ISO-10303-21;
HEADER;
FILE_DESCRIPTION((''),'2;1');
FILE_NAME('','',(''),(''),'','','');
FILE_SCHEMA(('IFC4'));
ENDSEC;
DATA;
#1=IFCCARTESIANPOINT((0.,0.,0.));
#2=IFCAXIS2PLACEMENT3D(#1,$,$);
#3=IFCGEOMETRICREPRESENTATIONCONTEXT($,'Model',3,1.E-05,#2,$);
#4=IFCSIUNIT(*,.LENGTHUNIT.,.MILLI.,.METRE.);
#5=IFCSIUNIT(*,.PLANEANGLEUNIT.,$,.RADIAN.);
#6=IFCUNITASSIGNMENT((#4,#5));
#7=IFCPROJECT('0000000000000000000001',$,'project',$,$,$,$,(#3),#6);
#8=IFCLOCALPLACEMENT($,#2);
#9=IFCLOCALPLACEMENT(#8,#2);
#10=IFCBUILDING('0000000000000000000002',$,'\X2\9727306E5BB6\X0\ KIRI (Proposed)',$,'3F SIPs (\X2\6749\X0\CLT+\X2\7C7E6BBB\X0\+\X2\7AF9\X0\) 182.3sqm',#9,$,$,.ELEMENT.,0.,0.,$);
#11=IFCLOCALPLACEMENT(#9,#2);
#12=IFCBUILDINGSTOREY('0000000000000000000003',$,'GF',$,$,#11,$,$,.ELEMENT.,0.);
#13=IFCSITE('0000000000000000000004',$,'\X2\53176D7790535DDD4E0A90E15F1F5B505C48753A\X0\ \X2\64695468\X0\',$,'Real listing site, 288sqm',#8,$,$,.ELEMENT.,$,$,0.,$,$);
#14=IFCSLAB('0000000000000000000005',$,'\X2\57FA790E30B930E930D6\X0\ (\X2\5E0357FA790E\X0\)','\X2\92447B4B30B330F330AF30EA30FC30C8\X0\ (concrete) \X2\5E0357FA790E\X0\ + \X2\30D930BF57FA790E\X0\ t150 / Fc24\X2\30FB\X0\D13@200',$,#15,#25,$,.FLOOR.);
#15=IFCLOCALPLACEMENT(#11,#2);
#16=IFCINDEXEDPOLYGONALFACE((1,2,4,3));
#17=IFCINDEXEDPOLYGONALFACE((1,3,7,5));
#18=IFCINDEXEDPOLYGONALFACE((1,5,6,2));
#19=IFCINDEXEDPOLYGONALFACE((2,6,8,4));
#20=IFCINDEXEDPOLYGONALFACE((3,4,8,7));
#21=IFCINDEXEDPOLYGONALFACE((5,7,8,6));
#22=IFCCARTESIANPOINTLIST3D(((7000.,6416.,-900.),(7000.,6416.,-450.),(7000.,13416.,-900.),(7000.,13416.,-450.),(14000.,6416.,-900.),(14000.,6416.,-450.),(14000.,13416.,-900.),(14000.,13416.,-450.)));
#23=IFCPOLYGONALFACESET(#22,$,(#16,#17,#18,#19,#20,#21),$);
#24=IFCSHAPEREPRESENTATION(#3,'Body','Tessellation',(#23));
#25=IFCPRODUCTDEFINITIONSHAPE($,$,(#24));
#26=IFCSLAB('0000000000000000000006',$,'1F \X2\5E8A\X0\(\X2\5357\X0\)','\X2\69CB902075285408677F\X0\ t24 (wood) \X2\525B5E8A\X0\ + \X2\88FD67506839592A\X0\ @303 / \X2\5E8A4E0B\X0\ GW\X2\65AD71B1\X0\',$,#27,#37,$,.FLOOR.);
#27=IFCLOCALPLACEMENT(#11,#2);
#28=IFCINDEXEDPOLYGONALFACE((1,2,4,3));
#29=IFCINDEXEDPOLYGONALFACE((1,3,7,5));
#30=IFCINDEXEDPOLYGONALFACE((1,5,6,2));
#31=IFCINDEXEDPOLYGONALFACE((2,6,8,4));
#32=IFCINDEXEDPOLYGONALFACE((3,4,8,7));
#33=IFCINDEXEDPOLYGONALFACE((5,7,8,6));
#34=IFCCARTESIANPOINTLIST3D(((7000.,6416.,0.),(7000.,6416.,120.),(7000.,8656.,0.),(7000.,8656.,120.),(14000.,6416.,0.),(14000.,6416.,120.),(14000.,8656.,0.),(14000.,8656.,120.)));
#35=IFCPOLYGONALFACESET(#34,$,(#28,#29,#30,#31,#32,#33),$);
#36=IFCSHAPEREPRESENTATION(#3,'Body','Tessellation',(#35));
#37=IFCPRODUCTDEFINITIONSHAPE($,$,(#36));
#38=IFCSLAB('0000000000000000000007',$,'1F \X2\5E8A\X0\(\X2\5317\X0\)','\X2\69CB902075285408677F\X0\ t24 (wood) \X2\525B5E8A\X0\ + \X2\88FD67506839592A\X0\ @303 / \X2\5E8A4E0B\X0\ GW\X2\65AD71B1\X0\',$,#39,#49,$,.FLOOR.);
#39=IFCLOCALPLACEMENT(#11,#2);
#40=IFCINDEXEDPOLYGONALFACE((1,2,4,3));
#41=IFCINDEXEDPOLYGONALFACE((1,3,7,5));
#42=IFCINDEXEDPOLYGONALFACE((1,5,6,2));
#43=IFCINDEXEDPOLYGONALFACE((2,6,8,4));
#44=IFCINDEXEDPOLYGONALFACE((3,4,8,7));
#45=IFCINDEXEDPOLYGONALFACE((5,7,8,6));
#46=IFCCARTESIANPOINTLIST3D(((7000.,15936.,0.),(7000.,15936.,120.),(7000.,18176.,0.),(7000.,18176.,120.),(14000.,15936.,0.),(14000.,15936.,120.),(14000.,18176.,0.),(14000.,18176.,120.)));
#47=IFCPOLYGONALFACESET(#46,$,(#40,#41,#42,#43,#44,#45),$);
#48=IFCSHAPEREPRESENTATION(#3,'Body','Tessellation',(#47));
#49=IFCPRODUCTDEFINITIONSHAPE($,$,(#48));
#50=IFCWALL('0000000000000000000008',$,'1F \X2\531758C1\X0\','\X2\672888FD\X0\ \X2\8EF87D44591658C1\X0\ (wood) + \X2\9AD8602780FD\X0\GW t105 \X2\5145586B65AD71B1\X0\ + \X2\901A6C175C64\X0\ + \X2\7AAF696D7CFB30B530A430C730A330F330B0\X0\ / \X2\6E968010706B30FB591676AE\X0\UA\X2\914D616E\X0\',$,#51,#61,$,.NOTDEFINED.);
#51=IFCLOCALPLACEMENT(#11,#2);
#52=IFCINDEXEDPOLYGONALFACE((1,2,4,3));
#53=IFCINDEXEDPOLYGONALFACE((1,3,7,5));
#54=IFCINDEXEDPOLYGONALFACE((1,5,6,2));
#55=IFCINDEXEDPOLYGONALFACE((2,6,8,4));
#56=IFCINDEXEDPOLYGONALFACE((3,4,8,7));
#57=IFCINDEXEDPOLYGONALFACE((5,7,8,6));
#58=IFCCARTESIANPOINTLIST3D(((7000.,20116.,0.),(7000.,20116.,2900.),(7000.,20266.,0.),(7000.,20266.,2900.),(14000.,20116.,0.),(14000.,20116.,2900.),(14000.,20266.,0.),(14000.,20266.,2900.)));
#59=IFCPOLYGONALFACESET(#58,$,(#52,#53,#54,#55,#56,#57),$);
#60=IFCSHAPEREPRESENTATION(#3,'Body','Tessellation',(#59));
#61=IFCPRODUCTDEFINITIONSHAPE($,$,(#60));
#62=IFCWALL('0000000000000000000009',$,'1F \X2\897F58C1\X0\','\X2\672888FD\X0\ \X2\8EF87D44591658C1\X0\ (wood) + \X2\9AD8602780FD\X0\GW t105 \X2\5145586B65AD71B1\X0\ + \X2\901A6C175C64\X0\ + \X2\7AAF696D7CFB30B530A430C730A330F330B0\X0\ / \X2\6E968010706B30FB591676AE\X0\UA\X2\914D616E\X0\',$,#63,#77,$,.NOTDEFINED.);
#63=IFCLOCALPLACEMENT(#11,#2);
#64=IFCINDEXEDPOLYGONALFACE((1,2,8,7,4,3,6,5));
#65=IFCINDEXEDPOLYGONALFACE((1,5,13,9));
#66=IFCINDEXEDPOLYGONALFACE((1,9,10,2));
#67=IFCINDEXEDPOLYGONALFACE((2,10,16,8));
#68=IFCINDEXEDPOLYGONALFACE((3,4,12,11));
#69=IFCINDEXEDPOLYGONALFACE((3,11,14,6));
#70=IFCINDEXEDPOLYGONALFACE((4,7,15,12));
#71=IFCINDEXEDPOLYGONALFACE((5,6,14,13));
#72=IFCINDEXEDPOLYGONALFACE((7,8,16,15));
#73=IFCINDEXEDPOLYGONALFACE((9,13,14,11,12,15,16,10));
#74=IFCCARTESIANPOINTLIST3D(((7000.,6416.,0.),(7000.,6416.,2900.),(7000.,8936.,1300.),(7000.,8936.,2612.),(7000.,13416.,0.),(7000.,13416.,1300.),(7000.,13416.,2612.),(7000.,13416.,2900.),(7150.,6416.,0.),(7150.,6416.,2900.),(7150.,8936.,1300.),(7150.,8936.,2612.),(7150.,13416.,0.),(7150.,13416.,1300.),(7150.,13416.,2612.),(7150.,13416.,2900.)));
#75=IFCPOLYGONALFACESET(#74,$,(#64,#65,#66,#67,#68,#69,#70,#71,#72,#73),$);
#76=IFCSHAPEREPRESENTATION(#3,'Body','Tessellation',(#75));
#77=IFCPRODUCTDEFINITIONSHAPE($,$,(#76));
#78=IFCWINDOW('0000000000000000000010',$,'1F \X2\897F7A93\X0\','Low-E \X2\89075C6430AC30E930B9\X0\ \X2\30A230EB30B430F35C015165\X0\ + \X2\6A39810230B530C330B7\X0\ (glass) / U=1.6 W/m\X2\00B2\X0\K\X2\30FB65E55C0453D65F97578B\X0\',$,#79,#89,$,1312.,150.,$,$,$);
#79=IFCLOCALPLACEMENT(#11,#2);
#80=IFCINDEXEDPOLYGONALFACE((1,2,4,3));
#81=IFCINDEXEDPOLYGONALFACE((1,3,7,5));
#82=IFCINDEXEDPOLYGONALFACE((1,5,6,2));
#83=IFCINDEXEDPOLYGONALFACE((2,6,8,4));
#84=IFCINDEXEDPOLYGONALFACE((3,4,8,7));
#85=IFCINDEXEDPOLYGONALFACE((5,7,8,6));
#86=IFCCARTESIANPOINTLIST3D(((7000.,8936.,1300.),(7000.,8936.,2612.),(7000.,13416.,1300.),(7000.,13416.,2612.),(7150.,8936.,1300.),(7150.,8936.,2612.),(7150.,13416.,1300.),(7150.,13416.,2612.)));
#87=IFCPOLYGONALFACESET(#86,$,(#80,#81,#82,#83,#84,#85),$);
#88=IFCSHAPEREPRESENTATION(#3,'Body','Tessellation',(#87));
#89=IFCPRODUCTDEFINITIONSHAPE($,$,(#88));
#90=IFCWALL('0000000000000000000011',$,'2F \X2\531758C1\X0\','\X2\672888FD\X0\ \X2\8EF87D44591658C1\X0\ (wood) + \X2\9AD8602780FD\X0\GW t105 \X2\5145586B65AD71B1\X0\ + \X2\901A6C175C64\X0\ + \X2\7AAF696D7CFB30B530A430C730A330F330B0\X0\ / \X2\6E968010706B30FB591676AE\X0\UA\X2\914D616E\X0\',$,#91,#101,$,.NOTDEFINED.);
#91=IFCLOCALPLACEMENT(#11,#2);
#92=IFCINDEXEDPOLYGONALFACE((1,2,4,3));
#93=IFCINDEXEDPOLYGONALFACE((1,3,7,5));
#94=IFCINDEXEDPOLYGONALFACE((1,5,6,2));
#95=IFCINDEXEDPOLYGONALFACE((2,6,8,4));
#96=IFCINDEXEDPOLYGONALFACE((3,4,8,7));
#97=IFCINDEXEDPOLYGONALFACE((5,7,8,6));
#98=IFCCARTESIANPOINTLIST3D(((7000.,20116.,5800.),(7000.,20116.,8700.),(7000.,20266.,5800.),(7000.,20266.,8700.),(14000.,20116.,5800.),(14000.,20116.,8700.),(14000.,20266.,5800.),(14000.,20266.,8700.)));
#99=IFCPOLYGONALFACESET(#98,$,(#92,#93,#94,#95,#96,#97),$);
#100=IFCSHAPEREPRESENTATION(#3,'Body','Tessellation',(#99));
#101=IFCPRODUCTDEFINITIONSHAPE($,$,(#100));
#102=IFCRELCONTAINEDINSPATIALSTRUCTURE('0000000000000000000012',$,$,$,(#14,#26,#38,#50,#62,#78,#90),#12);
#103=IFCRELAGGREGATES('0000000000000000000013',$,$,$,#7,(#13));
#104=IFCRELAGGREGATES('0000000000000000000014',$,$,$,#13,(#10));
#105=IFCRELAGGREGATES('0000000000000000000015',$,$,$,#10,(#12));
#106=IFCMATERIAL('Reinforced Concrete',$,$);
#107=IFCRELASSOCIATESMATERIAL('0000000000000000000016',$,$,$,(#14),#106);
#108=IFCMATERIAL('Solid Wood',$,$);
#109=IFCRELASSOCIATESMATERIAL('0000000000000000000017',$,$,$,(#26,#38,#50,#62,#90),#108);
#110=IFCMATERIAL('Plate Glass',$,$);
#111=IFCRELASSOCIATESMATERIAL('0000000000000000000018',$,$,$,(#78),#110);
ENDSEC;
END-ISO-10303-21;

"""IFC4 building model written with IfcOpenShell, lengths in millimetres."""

from ifc_helpers import new_model, si_unit, frame, frame_2d, origin, place, context, project, spatial, rectangle, extrude, material, element, fill, save


model = new_model("IFC4")

# Units and contexts
model_context = context("Model", 3, precision=1e-05, world=origin())
ifc_project = project(units=[si_unit("LENGTHUNIT", "METRE", prefix="MILLI"), si_unit("PLANEANGLEUNIT", "RADIAN")], contexts=[model_context])

# Site, building, storey
site_placement = place(None, origin())
site = spatial("IfcSite", under=ifc_project, at=site_placement, Name="北海道川上郡弟子屈町 摩周", ObjectType="Real listing site, 288sqm", CompositionType="ELEMENT", RefElevation=0.0)
building_placement = place(site_placement, origin())
building = spatial("IfcBuilding", under=site, at=building_placement, Name="霧の家 KIRI (Proposed)", ObjectType="3F SIPs (杉CLT+籾殻+竹) 182.3sqm", CompositionType="ELEMENT", ElevationOfRefHeight=0.0, ElevationOfTerrain=0.0)
storey_placement = place(building_placement, origin())
storey = spatial("IfcBuildingStorey", under=building, at=storey_placement, Name="GF", CompositionType="ELEMENT", Elevation=0.0)

# Slabs
ifc_material_1 = material(Name="Reinforced Concrete")
slab_1_placement = place(storey_placement, frame((3500.0, 3208.0, -450.0)))
element("IfcSlab", 1, at=slab_1_placement, inside=storey, material=ifc_material_1, Name="基礎スラブ (布基礎)", Description="鉄筋コンクリート (concrete) 布基礎 + ベタ基礎 t150 / Fc24・D13@200", PredefinedType="FLOOR", context=model_context, shape_type="SweptSolid", body=[
    extrude(rectangle(XDim=7000.0, YDim=7000.0, at=frame_2d((3500.0, 3500.0))), frame((3500.0, 3208.0, -450.0)), (0.0, 0.0, 1.0), 450.0),
])
ifc_material_2 = material(Name="Solid Wood")
slab_2_placement = place(storey_placement, frame((3500.0, 3208.0, 0.0)))
element("IfcSlab", 2, at=slab_2_placement, inside=storey, material=ifc_material_2, Name="1F 床(南)", Description="構造用合板 t24 (wood) 剛床 + 製材根太 @303 / 床下 GW断熱", PredefinedType="FLOOR", context=model_context, shape_type="SweptSolid", body=[
    extrude(rectangle(XDim=7000.0, YDim=2240.0, at=frame_2d((3500.0, 1120.0))), frame((3500.0, 3208.0, 0.0)), (0.0, 0.0, 1.0), 120.0),
])
slab_3_placement = place(storey_placement, frame((3500.0, 7968.0, 0.0)))
element("IfcSlab", 3, at=slab_3_placement, inside=storey, material=ifc_material_2, Name="1F 床(北)", Description="構造用合板 t24 (wood) 剛床 + 製材根太 @303 / 床下 GW断熱", PredefinedType="FLOOR", context=model_context, shape_type="SweptSolid", body=[
    extrude(rectangle(XDim=7000.0, YDim=2240.0, at=frame_2d((3500.0, 1120.0))), frame((3500.0, 7968.0, 0.0)), (0.0, 0.0, 1.0), 120.0),
])

# Shared definitions
ifc_material_3 = material(Name="Plate Glass")

# Wall
wall_1_placement = place(storey_placement, frame((3500.0, 10058.0, 0.0)))
element("IfcWall", 4, at=wall_1_placement, inside=storey, material=ifc_material_2, Name="1F 北壁", Description="木製 軸組外壁 (wood) + 高性能GW t105 充填断熱 + 通気層 + 窯業系サイディング / 準耐火・外皮UA配慮", PredefinedType="NOTDEFINED", context=model_context, shape_type="SweptSolid", body=[
    extrude(rectangle(XDim=7000.0, YDim=150.0, at=frame_2d((3500.0, 75.0))), frame((3500.0, 10058.0, 0.0)), (0.0, 0.0, 1.0), 2900.0),
])

# Wall, opening, window
wall_2_placement = place(storey_placement, frame((3500.0, 3208.0, 0.0)))
wall_2 = element("IfcWall", 5, at=wall_2_placement, inside=storey, material=ifc_material_2, Name="1F 西壁", Description="木製 軸組外壁 (wood) + 高性能GW t105 充填断熱 + 通気層 + 窯業系サイディング / 準耐火・外皮UA配慮", PredefinedType="NOTDEFINED", context=model_context, shape_type="SweptSolid", body=[
    extrude(rectangle(XDim=150.0, YDim=7000.0, at=frame_2d((75.0, 3500.0))), frame((3500.0, 3208.0, 0.0)), (0.0, 0.0, 1.0), 2900.0),
])
opening_1_placement = place(storey_placement, frame((3500.0, 4468.0, 650.0)))
opening_1 = element("IfcOpeningElement", 6, at=opening_1_placement, cuts=wall_2, PredefinedType="NOTDEFINED", context=model_context, shape_type="SweptSolid", body=[
    extrude(rectangle(XDim=150.0, YDim=4480.0, at=frame_2d((75.0, 2240.0))), frame((3500.0, 4468.0, 650.0)), (0.0, 0.0, 1.0), 1312.0),
])
window_1_placement = place(storey_placement, frame((3500.0, 4468.0, 650.0)))
window_1 = element("IfcWindow", 7, at=window_1_placement, inside=storey, material=ifc_material_3, Name="1F 西窓", Description="Low-E 複層ガラス アルゴン封入 + 樹脂サッシ (glass) / U=1.6 W/m²K・日射取得型", OverallHeight=1312.0, OverallWidth=150.0, context=model_context, shape_type="SweptSolid", body=[
    extrude(rectangle(XDim=150.0, YDim=4480.0, at=frame_2d((75.0, 2240.0))), frame((3500.0, 4468.0, 650.0)), (0.0, 0.0, 1.0), 1312.0),
])
fill(opening_1, window_1)

# Wall
wall_3_placement = place(storey_placement, frame((3500.0, 10058.0, 2900.0)))
element("IfcWall", 8, at=wall_3_placement, inside=storey, material=ifc_material_2, Name="2F 北壁", Description="木製 軸組外壁 (wood) + 高性能GW t105 充填断熱 + 通気層 + 窯業系サイディング / 準耐火・外皮UA配慮", PredefinedType="NOTDEFINED", context=model_context, shape_type="SweptSolid", body=[
    extrude(rectangle(XDim=7000.0, YDim=150.0, at=frame_2d((3500.0, 75.0))), frame((3500.0, 10058.0, 2900.0)), (0.0, 0.0, 1.0), 2900.0),
])

save(model, "model.ifc")
